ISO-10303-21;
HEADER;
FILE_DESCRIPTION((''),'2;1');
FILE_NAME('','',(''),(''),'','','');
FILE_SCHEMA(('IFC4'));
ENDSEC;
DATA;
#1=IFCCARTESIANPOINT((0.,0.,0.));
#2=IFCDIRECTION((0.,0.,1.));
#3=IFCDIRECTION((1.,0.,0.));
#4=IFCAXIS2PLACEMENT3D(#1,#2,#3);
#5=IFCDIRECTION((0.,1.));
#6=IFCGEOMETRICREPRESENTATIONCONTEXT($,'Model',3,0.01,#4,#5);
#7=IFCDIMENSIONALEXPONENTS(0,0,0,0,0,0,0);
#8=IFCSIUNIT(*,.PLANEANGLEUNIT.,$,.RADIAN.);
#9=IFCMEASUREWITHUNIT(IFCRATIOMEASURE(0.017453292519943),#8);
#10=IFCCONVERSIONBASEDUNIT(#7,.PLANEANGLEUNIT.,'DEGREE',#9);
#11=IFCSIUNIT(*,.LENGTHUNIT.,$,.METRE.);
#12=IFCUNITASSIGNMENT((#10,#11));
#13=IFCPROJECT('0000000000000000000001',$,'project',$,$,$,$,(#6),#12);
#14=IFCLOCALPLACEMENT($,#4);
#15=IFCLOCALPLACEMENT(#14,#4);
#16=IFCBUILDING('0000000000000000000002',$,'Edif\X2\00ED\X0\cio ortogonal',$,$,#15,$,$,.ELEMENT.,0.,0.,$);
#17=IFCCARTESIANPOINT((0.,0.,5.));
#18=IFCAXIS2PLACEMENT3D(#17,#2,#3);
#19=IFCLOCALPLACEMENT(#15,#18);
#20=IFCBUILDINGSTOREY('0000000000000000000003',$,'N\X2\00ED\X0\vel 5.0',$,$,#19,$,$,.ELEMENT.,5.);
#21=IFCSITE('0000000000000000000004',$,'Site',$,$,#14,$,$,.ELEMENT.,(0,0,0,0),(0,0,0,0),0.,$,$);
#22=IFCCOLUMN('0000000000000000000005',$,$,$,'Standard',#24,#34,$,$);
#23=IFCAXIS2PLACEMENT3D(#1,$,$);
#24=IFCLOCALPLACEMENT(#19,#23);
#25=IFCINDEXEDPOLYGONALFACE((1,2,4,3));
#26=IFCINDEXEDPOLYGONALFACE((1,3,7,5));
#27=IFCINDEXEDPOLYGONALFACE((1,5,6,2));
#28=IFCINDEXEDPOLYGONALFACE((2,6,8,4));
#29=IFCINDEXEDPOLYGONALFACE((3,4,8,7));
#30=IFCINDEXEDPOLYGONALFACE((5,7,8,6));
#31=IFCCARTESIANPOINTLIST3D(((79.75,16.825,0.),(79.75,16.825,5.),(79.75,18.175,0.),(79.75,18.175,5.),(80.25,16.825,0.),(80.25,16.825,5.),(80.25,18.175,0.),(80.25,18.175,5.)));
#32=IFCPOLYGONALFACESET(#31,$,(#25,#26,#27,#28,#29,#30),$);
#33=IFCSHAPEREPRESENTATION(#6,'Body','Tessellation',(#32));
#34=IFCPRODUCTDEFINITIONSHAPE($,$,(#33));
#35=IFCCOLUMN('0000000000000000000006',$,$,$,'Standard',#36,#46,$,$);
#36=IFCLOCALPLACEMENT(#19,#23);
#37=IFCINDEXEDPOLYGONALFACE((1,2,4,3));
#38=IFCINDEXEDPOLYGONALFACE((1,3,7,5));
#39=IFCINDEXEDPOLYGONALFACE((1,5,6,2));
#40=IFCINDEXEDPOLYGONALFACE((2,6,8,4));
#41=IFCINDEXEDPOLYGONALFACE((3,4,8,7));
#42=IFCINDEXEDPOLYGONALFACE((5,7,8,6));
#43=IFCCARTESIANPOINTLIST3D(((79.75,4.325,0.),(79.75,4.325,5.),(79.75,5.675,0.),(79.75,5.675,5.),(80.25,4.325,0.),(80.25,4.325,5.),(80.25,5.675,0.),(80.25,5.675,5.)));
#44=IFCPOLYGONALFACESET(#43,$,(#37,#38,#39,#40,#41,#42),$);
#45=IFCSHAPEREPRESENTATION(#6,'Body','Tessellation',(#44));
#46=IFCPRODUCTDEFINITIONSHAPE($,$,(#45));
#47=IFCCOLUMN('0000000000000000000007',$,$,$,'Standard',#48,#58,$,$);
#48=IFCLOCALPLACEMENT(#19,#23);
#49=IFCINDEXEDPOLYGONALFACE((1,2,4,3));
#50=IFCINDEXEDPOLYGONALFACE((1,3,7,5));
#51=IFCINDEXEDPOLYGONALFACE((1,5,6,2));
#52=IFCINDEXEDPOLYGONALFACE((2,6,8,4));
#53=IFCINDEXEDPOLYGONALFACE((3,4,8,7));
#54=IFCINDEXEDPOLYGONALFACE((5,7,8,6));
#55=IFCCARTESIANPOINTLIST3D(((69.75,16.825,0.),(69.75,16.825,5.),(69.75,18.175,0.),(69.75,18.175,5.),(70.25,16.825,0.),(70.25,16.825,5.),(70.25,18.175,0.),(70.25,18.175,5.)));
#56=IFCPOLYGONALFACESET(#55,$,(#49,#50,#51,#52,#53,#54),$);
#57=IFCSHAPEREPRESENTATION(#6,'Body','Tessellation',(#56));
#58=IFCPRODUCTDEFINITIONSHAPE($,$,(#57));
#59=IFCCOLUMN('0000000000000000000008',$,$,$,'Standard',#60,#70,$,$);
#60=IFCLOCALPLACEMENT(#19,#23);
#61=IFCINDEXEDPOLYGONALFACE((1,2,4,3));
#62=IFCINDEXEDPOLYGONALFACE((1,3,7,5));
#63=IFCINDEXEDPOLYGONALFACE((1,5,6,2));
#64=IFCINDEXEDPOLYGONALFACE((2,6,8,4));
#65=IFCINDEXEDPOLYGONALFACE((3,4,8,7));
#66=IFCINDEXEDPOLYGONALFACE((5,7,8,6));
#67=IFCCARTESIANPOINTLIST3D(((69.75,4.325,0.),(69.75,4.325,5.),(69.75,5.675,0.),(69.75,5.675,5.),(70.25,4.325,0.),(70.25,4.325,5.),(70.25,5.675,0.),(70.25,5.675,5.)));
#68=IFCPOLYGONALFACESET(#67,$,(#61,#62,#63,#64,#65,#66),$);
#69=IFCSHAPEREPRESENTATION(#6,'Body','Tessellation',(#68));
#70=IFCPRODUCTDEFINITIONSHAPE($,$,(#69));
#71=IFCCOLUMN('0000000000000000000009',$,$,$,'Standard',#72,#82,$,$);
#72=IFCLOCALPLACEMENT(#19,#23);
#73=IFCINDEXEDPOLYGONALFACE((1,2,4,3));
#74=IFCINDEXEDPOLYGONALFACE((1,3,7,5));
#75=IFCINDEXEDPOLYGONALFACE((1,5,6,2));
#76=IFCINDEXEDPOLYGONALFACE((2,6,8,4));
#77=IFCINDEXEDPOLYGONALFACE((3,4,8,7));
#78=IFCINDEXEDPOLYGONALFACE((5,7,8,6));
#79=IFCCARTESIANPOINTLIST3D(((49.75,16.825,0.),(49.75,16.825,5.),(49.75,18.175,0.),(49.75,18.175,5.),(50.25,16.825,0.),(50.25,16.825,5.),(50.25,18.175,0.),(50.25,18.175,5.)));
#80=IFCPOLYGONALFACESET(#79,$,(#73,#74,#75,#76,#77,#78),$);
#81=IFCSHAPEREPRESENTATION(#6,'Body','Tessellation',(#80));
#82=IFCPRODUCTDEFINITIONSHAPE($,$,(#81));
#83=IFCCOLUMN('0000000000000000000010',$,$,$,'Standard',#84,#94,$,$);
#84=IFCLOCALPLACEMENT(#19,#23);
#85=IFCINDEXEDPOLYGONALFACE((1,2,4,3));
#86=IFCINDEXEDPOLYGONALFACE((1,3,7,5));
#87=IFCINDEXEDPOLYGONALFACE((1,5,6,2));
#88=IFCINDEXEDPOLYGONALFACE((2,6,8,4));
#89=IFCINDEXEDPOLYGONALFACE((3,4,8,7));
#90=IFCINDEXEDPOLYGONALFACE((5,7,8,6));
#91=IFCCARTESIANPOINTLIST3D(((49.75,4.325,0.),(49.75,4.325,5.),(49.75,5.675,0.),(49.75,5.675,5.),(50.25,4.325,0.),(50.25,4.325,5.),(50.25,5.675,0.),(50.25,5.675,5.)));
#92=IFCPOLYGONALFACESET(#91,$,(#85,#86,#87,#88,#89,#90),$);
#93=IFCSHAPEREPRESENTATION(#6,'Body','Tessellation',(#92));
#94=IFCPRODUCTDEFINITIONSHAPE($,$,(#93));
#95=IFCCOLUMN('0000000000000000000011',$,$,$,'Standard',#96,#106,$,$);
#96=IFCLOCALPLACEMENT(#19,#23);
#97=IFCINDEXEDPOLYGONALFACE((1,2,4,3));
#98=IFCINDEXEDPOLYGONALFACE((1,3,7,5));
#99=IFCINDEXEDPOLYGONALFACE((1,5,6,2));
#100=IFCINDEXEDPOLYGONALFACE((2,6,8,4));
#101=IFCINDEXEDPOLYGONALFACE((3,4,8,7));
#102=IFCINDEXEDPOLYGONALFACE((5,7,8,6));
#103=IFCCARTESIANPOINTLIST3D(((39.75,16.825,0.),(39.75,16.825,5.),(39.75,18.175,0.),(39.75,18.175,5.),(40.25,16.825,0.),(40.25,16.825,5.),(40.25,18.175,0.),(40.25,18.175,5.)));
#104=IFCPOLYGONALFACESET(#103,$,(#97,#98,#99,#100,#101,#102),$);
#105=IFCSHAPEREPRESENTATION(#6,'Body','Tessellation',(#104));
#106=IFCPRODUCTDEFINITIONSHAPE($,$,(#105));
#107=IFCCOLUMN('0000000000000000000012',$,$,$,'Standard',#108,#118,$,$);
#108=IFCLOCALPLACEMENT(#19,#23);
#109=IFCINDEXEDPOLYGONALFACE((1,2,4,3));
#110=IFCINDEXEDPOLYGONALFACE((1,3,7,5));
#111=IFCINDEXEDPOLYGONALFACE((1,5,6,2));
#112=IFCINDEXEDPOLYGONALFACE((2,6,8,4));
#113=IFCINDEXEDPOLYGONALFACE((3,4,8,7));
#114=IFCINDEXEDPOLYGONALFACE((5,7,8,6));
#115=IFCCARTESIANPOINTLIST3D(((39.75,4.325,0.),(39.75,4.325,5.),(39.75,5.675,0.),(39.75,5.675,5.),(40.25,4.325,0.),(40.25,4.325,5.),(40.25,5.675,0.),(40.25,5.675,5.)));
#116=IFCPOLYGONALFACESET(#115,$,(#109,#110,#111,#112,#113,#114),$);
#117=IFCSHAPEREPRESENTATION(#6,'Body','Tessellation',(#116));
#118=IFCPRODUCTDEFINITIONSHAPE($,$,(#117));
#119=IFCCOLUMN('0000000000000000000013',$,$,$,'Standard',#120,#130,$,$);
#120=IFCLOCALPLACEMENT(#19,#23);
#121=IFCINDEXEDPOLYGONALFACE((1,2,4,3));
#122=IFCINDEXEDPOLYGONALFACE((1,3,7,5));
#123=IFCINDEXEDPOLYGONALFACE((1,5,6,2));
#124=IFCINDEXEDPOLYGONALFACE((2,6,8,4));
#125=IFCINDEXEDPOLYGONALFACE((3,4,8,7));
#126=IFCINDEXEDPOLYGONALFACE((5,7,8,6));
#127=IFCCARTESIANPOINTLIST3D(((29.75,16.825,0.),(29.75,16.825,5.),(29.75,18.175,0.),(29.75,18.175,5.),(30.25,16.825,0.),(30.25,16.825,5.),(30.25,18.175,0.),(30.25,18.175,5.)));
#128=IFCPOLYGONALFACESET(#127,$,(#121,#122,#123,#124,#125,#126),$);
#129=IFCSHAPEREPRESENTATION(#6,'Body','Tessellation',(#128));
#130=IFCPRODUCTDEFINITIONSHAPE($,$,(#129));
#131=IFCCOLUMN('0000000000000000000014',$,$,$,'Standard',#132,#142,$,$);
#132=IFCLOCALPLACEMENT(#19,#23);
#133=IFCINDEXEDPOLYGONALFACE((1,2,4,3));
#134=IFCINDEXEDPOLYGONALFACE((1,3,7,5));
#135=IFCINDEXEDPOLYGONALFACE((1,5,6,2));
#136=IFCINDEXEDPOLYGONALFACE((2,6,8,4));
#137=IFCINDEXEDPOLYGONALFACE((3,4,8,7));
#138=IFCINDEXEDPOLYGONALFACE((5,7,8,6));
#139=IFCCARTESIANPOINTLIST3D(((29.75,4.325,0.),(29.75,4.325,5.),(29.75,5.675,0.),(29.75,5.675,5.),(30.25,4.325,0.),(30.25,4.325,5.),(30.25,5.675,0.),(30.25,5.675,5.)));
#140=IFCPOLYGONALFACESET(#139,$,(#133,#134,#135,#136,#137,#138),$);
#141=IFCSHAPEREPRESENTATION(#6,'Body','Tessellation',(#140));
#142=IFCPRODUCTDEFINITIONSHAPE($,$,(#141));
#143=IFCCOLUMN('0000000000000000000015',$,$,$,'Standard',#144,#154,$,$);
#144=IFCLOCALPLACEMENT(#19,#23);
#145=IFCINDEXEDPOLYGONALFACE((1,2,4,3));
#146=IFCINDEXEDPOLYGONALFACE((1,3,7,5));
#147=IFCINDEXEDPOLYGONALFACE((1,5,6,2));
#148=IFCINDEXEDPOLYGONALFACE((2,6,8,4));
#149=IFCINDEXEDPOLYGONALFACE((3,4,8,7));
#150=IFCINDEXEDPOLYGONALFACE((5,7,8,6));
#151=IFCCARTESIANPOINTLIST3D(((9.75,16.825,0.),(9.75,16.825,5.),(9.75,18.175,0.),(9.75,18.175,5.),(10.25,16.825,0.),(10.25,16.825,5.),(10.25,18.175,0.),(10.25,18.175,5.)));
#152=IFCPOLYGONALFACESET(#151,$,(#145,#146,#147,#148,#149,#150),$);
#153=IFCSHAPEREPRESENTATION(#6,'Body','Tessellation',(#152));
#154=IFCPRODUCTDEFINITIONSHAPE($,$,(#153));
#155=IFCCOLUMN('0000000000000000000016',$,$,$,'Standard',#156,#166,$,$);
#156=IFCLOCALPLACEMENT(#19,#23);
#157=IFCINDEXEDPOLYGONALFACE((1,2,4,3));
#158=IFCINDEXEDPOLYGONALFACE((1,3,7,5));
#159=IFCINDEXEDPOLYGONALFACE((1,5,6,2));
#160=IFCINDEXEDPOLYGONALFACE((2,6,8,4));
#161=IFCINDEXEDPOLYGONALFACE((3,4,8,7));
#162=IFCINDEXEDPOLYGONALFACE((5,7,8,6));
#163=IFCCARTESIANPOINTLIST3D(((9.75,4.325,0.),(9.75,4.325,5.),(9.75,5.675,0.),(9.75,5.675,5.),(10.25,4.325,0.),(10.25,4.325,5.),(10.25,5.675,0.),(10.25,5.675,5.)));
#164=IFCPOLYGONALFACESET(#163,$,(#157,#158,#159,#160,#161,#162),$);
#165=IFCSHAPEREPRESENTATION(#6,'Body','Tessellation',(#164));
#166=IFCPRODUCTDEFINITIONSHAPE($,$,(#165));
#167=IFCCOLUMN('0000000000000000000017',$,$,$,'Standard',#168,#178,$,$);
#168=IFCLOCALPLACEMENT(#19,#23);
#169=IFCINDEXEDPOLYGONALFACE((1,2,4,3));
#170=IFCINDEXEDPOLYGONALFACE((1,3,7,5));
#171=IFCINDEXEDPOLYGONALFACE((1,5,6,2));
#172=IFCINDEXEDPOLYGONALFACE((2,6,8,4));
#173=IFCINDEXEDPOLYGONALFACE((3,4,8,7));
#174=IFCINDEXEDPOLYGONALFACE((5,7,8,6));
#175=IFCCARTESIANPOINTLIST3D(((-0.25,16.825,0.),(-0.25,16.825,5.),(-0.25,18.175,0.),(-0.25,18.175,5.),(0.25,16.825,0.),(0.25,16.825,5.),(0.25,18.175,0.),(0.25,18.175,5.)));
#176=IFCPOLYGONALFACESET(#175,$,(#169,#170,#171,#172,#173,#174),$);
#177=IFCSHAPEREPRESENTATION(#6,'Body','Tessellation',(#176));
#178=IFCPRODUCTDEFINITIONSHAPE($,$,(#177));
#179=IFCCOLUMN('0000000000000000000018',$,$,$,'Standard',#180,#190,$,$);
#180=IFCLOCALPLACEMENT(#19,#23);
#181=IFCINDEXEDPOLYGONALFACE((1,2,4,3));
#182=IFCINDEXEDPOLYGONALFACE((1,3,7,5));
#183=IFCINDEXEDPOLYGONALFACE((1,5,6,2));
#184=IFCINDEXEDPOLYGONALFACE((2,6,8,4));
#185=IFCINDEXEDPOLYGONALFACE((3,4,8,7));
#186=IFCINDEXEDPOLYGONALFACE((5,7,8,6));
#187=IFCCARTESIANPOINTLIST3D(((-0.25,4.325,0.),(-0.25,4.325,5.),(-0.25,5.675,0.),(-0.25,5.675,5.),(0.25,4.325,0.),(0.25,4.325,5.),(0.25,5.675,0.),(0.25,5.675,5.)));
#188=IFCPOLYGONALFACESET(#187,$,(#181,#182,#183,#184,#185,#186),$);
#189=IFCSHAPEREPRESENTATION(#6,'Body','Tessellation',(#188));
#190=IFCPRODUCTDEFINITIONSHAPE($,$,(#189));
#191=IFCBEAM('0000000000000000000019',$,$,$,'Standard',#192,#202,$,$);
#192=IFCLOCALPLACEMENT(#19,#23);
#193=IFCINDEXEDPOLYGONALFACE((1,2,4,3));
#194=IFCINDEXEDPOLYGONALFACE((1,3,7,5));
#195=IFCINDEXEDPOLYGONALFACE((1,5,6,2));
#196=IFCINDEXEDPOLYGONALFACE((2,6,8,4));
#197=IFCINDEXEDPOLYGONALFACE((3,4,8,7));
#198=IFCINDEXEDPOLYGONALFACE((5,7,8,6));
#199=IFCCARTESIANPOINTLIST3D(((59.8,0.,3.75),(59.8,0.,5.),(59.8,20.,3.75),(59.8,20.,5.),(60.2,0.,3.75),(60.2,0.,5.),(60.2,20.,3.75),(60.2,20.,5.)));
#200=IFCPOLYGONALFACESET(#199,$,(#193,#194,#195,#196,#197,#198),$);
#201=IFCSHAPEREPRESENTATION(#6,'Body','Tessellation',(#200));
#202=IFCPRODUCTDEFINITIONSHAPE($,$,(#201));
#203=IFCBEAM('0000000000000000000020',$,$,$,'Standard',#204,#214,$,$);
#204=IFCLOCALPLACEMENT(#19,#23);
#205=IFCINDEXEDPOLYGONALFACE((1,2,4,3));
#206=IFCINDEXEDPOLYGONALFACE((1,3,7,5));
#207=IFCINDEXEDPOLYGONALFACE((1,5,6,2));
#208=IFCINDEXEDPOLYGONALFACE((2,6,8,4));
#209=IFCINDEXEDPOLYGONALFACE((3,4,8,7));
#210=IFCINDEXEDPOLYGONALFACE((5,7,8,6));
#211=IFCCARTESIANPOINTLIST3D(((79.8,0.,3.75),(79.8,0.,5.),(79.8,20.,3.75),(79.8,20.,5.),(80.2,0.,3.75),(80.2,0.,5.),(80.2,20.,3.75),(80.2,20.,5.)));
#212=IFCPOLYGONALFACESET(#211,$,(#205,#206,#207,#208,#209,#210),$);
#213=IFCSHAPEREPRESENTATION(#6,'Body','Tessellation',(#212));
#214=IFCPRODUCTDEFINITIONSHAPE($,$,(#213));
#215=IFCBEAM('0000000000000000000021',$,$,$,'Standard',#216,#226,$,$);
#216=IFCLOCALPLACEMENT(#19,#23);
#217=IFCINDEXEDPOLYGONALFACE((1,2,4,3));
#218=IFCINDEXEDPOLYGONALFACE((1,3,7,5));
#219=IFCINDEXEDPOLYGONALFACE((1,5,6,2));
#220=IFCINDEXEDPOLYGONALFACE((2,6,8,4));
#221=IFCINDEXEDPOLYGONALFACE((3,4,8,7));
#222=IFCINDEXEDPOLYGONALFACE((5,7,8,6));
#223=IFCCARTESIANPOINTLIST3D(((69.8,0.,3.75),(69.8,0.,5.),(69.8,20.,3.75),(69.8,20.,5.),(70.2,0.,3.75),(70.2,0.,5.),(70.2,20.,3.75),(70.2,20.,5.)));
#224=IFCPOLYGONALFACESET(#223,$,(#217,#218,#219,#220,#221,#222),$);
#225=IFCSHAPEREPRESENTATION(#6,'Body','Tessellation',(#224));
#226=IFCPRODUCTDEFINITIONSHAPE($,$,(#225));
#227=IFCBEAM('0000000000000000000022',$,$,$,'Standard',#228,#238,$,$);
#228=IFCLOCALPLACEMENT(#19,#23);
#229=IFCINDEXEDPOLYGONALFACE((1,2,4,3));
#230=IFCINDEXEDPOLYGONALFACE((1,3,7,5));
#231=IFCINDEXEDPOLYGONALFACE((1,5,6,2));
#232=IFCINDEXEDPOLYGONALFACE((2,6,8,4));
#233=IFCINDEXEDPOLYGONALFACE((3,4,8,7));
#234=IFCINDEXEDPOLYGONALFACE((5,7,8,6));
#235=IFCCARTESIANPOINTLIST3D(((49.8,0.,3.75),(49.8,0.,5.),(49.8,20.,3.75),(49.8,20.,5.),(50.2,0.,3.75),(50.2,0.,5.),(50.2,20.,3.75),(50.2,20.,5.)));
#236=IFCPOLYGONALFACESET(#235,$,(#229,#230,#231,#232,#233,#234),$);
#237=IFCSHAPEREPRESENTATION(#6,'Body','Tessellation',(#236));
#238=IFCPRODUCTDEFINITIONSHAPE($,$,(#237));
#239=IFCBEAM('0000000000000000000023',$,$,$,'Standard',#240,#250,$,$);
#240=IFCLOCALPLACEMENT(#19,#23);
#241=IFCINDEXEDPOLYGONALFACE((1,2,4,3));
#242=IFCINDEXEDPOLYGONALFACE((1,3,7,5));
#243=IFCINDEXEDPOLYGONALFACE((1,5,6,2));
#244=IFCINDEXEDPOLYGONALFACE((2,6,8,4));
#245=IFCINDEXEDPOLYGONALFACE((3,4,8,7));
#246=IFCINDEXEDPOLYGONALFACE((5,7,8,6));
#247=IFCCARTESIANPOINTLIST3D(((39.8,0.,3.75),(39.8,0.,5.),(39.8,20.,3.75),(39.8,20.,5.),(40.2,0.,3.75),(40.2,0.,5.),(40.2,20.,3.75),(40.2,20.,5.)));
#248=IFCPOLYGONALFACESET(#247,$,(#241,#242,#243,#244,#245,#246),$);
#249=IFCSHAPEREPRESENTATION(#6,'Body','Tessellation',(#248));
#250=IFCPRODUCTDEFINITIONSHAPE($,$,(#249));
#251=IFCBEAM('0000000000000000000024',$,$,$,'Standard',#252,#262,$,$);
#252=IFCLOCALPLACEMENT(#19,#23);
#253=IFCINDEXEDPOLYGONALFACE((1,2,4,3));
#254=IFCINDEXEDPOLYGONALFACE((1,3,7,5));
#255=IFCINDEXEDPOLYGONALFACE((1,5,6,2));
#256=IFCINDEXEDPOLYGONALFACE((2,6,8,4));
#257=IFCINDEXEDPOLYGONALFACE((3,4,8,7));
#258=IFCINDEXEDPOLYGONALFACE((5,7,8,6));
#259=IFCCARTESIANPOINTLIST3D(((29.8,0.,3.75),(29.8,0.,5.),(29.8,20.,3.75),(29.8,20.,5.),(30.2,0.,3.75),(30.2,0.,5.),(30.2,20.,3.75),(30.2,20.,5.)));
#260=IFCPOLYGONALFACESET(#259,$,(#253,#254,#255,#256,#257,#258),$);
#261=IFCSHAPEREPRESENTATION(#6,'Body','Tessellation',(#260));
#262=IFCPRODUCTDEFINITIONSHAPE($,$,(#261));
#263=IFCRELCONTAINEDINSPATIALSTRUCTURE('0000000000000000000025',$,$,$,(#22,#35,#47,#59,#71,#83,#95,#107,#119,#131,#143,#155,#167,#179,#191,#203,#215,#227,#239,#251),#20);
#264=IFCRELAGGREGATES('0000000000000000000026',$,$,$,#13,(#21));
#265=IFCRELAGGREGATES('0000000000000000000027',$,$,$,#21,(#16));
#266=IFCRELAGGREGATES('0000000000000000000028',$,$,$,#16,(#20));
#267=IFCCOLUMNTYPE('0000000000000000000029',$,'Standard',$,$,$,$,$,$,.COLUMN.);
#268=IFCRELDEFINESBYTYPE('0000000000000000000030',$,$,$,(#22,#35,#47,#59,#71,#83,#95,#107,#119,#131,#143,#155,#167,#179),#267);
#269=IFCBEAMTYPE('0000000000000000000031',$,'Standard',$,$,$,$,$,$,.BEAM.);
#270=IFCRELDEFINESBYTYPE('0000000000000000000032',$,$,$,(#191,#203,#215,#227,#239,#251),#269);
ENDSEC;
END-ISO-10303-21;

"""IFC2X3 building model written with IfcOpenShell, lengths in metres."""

from ifc_helpers import new_model, entity, si_unit, converted_unit, direction, frame, origin_with_axes, origin_2d, place, context, project, spatial, polyline, rectangle, outline, extrude, type_object, element, save


model = new_model("IFC2X3")

# Units and contexts
model_context = context("Model", 3, precision=0.01, world=origin_with_axes(), true_north=direction((0.0, 1.0)))
ifc_project = project(units=[converted_unit("PLANEANGLEUNIT", "DEGREE", entity("IfcRatioMeasure", 0.017453292519943), si_unit("PLANEANGLEUNIT", "RADIAN"), dimensions=[0, 0, 0, 0, 0, 0, 0]), si_unit("LENGTHUNIT", "METRE")], contexts=[model_context])

# Site, building, storey
site_placement = place(None, origin_with_axes())
site = spatial("IfcSite", under=ifc_project, at=site_placement, Name="Site", CompositionType="ELEMENT", RefLatitude=(0, 0, 0, 0), RefLongitude=(0, 0, 0, 0), RefElevation=0.0)
building_placement = place(site_placement, origin_with_axes())
building = spatial("IfcBuilding", under=site, at=building_placement, Name="Edifício ortogonal", CompositionType="ELEMENT", ElevationOfRefHeight=0.0, ElevationOfTerrain=0.0)
storey_placement = place(building_placement, frame((0.0, 0.0, 5.0), z_axis=(0.0, 0.0, 1.0), x_axis=(1.0, 0.0, 0.0)))
storey = spatial("IfcBuildingStorey", under=building, at=storey_placement, Name="Nível 5.0", CompositionType="ELEMENT", Elevation=5.0)

# Columns
column_type = type_object("IfcColumnType", Name="Standard", PredefinedType="COLUMN")
for number, where, z_axis, x_axis in (
    (1, (80.0, 17.5, 5.0), (0.0, 0.0, 1.0), (1.0, 0.0, 0.0)),
    (2, (80.0, 5.0, 5.0), (0.0, 0.0, 1.0), (1.0, 0.0, 0.0)),
    (3, (70.0, 17.5, 5.0), (0.0, 0.0, 1.0), (1.0, 0.0, 0.0)),
    (4, (70.0, 5.0, 5.0), (0.0, 0.0, 1.0), (1.0, 0.0, 0.0)),
    (5, (50.0, 17.5, 5.0), (0.0, 0.0, 1.0), (1.0, 0.0, 0.0)),
    (6, (50.0, 5.0, 5.0), (0.0, 0.0, 1.0), (1.0, 0.0, 0.0)),
    (7, (40.0, 17.5, 5.0), (0.0, 0.0, 1.0), (1.0, 0.0, 0.0)),
    (8, (40.0, 5.0, 5.0), (0.0, 0.0, 1.0), (1.0, 0.0, 0.0)),
    (9, (30.0, 17.5, 5.0), (0.0, 0.0, 1.0), (1.0, 0.0, 0.0)),
    (10, (30.0, 5.0, 5.0), (0.0, 0.0, 1.0), (1.0, 0.0, 0.0)),
    (11, (10.0, 17.5, 5.0), (0.0, 0.0, 1.0), (1.0, 0.0, 0.0)),
    (12, (10.0, 5.0, 5.0), (0.0, 0.0, 1.0), (1.0, 0.0, 0.0)),
    (13, (0.0, 17.5, 5.0), (0.0, 0.0, 1.0), (1.0, 0.0, 0.0)),
    (14, (0.0, 5.0, 5.0), (0.0, 0.0, 1.0), (1.0, 0.0, 0.0)),
):
    element("IfcColumn", number, at=place(site_placement, frame(where, z_axis=z_axis, x_axis=x_axis)), inside=storey, type_object=column_type, ObjectType="Standard", context=model_context, shape_type="SweptSolid", body=[
        extrude(outline(polyline([(0.25, -0.675), (0.25, 0.675), (-0.25, 0.675), (-0.25, -0.675), (0.25, -0.675)])), origin_with_axes(), (0.0, 0.0, 1.0), 5.0),
    ])

# Beams
beam_type = type_object("IfcBeamType", Name="Standard", PredefinedType="BEAM")
for number, where, z_axis, x_axis in (
    (15, (60.0, 20.0, 10.0), (0.0, 0.0, 1.0), (0.0, -1.0, 0.0)),
    (16, (80.0, 20.0, 10.0), (0.0, 0.0, 1.0), (0.0, -1.0, 0.0)),
    (17, (70.0, 20.0, 10.0), (0.0, 0.0, 1.0), (0.0, -1.0, 0.0)),
    (18, (50.0, 20.0, 10.0), (0.0, 0.0, 1.0), (0.0, -1.0, 0.0)),
    (19, (40.0, 20.0, 10.0), (0.0, 0.0, 1.0), (0.0, -1.0, 0.0)),
    (20, (30.0, 20.0, 10.0), (0.0, 0.0, 1.0), (0.0, -1.0, 0.0)),
):
    element("IfcBeam", number, at=place(site_placement, frame(where, z_axis=z_axis, x_axis=x_axis)), inside=storey, type_object=beam_type, ObjectType="Standard", context=model_context, shape_type="SweptSolid", body=[
        extrude(rectangle(XDim=0.4, YDim=1.25, at=origin_2d()), frame((0.0, 0.0, -0.625), z_axis=(1.0, 0.0, 0.0), x_axis=(0.0, 1.0, 0.0)), (0.0, 0.0, 1.0), 20.0),
    ])

save(model, "model.ifc")
